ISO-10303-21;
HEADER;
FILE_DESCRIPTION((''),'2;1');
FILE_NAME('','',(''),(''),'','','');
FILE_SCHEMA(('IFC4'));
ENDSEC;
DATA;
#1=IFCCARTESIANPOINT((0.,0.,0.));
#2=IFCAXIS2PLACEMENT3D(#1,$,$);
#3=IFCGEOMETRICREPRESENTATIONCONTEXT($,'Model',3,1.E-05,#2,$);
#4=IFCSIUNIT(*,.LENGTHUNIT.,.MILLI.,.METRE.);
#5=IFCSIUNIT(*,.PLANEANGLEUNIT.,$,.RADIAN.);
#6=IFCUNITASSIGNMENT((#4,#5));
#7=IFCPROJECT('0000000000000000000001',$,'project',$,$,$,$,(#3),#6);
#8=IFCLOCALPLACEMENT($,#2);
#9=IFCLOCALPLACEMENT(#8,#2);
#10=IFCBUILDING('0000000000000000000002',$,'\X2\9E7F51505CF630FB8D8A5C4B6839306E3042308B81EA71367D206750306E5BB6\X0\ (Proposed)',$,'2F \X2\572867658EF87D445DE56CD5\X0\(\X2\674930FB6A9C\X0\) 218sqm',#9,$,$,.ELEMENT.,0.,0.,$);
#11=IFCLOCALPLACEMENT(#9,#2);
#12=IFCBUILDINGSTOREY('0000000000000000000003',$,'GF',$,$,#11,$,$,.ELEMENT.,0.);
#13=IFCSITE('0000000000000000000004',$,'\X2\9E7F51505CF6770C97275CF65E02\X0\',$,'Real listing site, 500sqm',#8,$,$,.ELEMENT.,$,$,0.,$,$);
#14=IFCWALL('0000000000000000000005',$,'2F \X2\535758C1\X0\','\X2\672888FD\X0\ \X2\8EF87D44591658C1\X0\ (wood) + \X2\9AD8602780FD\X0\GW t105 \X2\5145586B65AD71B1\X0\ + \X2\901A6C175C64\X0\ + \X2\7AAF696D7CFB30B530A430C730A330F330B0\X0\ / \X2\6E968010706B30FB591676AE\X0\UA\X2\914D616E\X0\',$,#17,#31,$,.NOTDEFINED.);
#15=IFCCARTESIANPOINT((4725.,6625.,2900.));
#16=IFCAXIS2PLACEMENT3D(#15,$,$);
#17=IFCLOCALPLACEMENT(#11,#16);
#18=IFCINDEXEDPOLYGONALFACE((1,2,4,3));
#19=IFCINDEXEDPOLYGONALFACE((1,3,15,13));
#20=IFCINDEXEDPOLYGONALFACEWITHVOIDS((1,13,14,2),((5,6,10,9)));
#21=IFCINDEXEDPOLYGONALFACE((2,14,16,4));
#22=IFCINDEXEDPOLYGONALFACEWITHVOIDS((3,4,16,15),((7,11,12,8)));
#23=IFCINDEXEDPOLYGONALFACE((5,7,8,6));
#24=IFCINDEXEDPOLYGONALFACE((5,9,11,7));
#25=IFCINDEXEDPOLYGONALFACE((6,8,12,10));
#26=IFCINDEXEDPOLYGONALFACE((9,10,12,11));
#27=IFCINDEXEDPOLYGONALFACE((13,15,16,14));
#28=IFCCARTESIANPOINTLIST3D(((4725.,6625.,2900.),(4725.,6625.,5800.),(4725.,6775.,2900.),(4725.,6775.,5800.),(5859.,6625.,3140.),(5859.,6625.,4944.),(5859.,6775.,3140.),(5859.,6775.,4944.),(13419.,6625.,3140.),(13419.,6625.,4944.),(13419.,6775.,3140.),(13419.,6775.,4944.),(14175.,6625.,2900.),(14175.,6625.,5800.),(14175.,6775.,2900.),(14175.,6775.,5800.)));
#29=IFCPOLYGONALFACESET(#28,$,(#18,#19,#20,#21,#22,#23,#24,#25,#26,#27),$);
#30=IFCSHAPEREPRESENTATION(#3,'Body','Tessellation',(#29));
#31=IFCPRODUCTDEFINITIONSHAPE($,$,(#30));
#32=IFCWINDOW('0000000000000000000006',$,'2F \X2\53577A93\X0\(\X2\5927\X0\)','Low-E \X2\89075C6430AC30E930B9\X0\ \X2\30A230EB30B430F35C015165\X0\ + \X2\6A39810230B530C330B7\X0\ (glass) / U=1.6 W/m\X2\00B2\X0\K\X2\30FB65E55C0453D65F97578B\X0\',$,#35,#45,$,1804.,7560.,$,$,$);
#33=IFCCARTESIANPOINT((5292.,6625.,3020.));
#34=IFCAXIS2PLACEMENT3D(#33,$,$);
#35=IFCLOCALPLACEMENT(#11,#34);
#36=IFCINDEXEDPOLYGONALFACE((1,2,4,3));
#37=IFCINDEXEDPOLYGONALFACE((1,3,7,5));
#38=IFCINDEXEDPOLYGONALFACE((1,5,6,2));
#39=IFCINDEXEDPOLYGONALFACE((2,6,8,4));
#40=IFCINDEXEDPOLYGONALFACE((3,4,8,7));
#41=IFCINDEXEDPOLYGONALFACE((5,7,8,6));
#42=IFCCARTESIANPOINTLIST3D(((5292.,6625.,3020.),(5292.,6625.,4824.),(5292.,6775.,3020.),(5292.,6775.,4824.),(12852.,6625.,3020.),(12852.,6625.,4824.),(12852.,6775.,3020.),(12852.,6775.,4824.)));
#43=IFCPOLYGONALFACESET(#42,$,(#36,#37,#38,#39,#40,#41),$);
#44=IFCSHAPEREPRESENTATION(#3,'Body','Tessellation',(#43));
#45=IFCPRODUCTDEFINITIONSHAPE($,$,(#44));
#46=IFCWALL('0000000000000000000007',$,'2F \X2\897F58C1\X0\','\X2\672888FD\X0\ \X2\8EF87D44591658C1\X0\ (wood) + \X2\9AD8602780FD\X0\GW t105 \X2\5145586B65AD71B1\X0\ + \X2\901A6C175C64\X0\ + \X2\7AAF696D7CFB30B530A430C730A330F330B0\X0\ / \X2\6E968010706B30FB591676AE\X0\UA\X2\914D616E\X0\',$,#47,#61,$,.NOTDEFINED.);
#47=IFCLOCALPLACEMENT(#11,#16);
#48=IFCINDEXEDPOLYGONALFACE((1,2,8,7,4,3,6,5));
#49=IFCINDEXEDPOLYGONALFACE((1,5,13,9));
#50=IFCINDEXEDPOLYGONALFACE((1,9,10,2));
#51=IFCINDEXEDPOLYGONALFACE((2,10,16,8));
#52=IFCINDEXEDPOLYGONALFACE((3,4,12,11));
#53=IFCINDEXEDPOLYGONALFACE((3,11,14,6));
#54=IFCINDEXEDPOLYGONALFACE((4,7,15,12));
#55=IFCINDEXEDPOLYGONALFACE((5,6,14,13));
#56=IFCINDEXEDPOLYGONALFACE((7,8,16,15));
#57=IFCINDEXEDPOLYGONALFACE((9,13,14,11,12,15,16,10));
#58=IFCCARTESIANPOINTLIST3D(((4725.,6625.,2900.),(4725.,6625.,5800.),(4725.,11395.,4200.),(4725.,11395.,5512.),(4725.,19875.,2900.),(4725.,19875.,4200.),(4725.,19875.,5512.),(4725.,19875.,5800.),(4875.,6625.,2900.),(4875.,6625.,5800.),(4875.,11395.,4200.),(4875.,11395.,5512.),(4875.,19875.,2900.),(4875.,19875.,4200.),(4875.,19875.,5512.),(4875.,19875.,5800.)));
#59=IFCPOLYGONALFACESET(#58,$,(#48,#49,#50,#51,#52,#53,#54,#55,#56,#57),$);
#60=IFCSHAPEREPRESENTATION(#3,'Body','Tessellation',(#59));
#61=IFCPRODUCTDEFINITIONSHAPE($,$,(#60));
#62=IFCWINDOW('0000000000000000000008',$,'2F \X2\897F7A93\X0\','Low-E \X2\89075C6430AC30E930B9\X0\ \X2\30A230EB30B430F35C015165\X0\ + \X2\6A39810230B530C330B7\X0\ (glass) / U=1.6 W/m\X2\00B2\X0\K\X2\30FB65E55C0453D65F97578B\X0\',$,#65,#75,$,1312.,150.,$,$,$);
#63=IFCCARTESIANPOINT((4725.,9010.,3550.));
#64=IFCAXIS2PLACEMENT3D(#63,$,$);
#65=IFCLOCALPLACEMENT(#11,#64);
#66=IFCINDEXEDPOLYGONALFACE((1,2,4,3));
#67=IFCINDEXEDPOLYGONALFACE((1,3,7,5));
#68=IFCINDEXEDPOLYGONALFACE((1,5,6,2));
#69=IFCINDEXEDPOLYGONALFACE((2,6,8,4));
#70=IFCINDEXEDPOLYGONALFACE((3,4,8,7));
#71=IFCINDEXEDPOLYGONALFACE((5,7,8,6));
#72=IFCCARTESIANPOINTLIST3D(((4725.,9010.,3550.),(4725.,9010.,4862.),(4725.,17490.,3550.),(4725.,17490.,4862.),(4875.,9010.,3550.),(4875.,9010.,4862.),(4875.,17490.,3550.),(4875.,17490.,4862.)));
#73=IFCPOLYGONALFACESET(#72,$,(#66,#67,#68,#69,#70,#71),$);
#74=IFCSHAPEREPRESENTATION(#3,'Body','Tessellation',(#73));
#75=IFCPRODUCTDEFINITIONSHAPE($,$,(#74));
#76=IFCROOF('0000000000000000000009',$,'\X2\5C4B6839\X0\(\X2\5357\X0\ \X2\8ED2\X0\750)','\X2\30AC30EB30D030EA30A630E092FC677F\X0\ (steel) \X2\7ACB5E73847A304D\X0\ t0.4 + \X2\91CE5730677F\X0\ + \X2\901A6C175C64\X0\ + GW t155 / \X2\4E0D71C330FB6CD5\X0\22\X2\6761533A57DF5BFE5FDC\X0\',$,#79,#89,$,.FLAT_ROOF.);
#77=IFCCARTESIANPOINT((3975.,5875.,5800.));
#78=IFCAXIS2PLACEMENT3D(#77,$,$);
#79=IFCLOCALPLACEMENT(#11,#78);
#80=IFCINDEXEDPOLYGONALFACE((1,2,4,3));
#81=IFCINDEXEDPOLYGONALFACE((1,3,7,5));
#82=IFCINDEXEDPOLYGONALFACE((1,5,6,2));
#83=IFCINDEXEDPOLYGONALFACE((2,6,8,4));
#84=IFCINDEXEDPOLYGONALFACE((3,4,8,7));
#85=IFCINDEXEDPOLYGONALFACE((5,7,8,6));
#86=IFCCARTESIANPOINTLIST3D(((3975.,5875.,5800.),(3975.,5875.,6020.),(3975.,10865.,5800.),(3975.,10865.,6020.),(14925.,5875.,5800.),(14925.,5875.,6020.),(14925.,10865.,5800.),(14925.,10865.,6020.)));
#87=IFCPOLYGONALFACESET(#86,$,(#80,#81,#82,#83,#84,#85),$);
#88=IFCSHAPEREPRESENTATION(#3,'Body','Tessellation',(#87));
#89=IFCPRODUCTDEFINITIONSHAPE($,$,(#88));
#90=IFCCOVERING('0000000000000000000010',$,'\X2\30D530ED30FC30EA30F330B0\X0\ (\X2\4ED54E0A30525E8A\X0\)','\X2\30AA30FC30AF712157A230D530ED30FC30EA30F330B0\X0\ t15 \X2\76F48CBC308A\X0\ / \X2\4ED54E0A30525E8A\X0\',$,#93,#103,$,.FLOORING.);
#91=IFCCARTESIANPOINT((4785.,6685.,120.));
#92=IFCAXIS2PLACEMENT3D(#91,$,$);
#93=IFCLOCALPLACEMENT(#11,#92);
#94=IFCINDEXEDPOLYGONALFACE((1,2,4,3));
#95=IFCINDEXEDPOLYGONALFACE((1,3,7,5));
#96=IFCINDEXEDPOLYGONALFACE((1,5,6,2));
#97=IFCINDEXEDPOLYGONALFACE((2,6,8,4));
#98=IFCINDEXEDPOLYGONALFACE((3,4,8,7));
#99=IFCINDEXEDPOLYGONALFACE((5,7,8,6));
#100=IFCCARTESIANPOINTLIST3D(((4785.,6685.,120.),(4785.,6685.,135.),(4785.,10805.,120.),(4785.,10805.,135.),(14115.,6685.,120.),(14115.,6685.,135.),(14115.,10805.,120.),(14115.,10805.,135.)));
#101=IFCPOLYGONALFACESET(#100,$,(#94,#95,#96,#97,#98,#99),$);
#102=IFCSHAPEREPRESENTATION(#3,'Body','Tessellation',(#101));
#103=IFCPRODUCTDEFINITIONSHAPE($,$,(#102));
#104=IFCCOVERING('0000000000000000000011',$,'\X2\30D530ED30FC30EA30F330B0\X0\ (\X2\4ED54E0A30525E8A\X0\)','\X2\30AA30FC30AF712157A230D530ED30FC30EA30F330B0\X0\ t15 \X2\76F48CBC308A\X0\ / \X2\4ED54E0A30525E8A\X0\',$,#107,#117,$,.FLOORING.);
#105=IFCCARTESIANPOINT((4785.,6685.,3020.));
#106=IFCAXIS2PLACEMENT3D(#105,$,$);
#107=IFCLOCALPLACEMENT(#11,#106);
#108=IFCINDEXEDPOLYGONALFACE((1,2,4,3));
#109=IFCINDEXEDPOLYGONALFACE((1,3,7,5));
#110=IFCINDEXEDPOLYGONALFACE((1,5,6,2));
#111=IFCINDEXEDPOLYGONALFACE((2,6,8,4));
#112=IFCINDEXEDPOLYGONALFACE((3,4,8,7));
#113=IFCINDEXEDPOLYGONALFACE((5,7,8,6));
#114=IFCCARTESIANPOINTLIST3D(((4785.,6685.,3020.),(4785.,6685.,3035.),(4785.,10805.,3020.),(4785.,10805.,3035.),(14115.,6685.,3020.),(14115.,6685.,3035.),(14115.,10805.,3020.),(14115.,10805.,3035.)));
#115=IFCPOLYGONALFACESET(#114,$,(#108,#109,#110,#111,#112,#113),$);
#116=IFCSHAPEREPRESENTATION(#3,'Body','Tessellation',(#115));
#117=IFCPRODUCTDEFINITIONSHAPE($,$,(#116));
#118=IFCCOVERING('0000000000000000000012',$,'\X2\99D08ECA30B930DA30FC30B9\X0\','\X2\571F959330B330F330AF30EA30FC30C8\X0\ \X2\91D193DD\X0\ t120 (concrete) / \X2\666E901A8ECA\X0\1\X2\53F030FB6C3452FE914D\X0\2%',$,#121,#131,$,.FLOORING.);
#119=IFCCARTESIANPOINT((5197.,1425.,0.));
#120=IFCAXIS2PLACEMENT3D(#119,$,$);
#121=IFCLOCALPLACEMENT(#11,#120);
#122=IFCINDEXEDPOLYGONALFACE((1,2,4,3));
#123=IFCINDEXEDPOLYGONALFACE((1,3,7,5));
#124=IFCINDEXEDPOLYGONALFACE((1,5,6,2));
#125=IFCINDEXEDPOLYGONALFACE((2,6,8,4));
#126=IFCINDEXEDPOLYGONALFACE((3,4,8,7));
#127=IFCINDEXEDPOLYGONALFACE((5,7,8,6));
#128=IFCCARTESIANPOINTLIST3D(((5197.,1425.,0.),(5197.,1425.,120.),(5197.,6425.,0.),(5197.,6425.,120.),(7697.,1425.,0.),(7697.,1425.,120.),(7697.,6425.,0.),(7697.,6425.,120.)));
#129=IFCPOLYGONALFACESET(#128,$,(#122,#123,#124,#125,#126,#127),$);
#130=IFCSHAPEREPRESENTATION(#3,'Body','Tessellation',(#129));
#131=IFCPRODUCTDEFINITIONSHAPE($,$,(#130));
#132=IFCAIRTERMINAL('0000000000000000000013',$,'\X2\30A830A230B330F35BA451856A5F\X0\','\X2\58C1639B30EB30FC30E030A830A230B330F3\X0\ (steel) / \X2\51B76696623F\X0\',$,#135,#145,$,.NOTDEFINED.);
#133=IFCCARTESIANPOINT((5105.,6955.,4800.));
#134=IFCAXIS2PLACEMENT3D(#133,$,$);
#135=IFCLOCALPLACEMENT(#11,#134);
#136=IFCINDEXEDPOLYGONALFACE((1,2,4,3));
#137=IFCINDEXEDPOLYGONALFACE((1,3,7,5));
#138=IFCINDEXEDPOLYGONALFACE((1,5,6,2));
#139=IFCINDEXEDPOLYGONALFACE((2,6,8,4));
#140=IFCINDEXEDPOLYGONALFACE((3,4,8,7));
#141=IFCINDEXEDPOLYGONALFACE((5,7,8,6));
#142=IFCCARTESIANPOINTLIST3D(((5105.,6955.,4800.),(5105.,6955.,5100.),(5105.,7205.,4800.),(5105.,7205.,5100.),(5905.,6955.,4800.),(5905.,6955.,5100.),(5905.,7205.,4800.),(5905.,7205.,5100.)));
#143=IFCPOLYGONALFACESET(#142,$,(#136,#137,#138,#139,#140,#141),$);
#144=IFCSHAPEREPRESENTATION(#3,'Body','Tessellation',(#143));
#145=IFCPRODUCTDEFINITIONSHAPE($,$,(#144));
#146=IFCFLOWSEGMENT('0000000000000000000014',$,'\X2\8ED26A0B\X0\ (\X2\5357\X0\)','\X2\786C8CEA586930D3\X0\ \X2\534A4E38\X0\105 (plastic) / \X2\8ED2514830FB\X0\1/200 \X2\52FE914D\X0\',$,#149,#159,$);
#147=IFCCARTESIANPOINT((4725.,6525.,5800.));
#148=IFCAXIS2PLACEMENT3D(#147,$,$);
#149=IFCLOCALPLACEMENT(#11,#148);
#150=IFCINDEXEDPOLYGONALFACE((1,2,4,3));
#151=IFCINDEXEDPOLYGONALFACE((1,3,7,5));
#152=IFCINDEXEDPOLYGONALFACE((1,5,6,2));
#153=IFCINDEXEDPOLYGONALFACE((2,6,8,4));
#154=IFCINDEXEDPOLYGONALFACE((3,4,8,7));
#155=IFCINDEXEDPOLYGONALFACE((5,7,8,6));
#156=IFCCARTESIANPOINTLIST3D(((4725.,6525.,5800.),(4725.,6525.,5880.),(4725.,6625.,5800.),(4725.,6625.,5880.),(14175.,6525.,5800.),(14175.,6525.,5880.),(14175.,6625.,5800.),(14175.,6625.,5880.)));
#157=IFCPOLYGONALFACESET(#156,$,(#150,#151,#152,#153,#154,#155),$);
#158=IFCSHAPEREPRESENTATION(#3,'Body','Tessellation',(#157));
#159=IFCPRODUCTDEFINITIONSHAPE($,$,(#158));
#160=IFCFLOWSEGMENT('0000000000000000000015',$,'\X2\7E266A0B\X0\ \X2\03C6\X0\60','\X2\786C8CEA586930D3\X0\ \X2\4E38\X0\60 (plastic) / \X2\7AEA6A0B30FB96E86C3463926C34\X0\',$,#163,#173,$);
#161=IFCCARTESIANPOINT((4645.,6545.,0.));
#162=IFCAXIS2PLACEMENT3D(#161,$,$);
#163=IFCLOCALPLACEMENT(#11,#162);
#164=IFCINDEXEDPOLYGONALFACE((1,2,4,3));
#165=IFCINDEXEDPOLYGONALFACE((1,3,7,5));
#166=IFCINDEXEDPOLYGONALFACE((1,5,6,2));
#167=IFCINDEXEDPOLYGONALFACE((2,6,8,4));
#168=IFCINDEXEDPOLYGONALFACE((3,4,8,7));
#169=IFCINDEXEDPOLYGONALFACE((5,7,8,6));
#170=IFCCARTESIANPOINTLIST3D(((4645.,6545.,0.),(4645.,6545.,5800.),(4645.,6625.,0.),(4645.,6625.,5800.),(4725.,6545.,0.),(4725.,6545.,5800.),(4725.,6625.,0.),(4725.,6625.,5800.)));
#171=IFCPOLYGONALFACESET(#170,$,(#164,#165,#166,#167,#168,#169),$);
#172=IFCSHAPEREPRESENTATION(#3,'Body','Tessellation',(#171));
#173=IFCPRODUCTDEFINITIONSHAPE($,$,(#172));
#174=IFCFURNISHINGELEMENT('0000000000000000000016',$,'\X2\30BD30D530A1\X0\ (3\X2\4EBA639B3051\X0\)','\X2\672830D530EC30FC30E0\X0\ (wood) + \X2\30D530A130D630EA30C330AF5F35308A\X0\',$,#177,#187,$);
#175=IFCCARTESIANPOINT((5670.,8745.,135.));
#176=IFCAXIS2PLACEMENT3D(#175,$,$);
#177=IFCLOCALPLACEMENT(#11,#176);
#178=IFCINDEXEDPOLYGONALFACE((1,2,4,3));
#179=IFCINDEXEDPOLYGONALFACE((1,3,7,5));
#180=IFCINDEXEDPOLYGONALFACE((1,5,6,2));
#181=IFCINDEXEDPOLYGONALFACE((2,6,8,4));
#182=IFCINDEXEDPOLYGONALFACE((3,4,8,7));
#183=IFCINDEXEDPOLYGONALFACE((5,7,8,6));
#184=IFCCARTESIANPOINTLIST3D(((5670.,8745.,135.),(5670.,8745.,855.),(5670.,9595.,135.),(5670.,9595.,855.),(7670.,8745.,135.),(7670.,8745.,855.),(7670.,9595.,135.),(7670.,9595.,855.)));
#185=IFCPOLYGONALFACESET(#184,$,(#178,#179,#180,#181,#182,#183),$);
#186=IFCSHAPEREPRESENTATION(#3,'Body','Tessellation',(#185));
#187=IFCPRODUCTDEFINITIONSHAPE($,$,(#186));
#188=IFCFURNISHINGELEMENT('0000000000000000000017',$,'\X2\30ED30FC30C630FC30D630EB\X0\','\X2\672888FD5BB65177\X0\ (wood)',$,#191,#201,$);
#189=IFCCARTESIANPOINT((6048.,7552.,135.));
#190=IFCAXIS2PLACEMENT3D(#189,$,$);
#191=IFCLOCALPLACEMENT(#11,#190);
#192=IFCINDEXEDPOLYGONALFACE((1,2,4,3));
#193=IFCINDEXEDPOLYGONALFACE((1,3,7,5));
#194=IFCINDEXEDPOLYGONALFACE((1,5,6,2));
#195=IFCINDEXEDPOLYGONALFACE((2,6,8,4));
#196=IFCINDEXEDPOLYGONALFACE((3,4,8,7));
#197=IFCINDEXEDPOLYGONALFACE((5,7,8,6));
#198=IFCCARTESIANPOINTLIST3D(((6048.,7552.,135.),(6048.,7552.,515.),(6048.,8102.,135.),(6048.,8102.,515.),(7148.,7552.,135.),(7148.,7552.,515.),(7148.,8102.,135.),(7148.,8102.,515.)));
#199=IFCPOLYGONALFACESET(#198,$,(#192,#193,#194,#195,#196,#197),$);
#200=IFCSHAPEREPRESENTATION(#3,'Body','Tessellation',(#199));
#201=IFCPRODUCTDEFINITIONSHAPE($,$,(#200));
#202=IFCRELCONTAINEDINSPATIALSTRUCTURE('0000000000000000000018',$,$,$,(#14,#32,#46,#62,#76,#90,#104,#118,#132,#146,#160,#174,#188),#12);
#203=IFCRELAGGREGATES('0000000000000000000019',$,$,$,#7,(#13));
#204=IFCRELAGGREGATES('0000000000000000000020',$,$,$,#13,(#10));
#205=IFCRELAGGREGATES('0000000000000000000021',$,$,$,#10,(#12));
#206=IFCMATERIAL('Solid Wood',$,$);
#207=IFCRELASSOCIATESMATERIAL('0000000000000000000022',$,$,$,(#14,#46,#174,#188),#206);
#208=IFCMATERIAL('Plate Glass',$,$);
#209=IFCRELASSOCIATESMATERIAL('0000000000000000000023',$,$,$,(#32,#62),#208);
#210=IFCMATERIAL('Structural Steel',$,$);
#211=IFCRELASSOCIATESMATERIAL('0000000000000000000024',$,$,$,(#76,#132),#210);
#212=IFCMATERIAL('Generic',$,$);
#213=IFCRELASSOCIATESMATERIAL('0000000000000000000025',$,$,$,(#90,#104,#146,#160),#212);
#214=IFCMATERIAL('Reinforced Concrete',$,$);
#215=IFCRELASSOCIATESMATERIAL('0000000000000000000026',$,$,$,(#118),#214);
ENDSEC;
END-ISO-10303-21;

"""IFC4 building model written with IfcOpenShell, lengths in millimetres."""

from ifc_helpers import new_model, si_unit, frame, frame_2d, origin, place, context, project, spatial, rectangle, extrude, material, element, fill, save


model = new_model("IFC4")

# Units and contexts
model_context = context("Model", 3, precision=1e-05, world=origin())
ifc_project = project(units=[si_unit("LENGTHUNIT", "METRE", prefix="MILLI"), si_unit("PLANEANGLEUNIT", "RADIAN")], contexts=[model_context])

# Site, building, storey
site_placement = place(None, origin())
site = spatial("IfcSite", under=ifc_project, at=site_placement, Name="鹿児島県霧島市", ObjectType="Real listing site, 500sqm", CompositionType="ELEMENT", RefElevation=0.0)
building_placement = place(site_placement, origin())
building = spatial("IfcBuilding", under=site, at=building_placement, Name="鹿児島・越屋根のある自然素材の家 (Proposed)", ObjectType="2F 在来軸組工法(杉・檜) 218sqm", CompositionType="ELEMENT", ElevationOfRefHeight=0.0, ElevationOfTerrain=0.0)
storey_placement = place(building_placement, origin())
storey = spatial("IfcBuildingStorey", under=building, at=storey_placement, Name="GF", CompositionType="ELEMENT", Elevation=0.0)

# Shared definitions
ifc_material_1 = material(Name="Solid Wood")

# Shared definitions
ifc_material_2 = material(Name="Reinforced Concrete")

# Shared definitions
ifc_material_3 = material(Name="Plate Glass")

# Walls, openings, windows
wall_1_placement = place(storey_placement, frame((4725.0, 6625.0, 2900.0)))
wall_1 = element("IfcWall", 1, at=wall_1_placement, inside=storey, material=ifc_material_1, Name="2F 南壁", Description="木製 軸組外壁 (wood) + 高性能GW t105 充填断熱 + 通気層 + 窯業系サイディング / 準耐火・外皮UA配慮", PredefinedType="NOTDEFINED", context=model_context, shape_type="SweptSolid", body=[
    extrude(rectangle(XDim=9450.0, YDim=150.0, at=frame_2d((4725.0, 75.0))), frame((4725.0, 6625.0, 2900.0)), (0.0, 0.0, 1.0), 2900.0),
])
opening_1_placement = place(storey_placement, frame((5292.0, 6625.0, 3020.0)))
opening_1 = element("IfcOpeningElement", 2, at=opening_1_placement, cuts=wall_1, PredefinedType="NOTDEFINED", context=model_context, shape_type="SweptSolid", body=[
    extrude(rectangle(XDim=7560.0, YDim=150.0, at=frame_2d((3780.0, 75.0))), frame((5292.0, 6625.0, 3020.0)), (0.0, 0.0, 1.0), 1804.0),
])
window_1_placement = place(storey_placement, frame((5292.0, 6625.0, 3020.0)))
window_1 = element("IfcWindow", 3, at=window_1_placement, inside=storey, material=ifc_material_3, Name="2F 南窓(大)", Description="Low-E 複層ガラス アルゴン封入 + 樹脂サッシ (glass) / U=1.6 W/m²K・日射取得型", OverallHeight=1804.0, OverallWidth=7560.0, context=model_context, shape_type="SweptSolid", body=[
    extrude(rectangle(XDim=7560.0, YDim=150.0, at=frame_2d((3780.0, 75.0))), frame((5292.0, 6625.0, 3020.0)), (0.0, 0.0, 1.0), 1804.0),
])
fill(opening_1, window_1)
wall_2_placement = place(storey_placement, frame((4725.0, 6625.0, 2900.0)))
wall_2 = element("IfcWall", 4, at=wall_2_placement, inside=storey, material=ifc_material_1, Name="2F 西壁", Description="木製 軸組外壁 (wood) + 高性能GW t105 充填断熱 + 通気層 + 窯業系サイディング / 準耐火・外皮UA配慮", PredefinedType="NOTDEFINED", context=model_context, shape_type="SweptSolid", body=[
    extrude(rectangle(XDim=150.0, YDim=13250.0, at=frame_2d((75.0, 6625.0))), frame((4725.0, 6625.0, 2900.0)), (0.0, 0.0, 1.0), 2900.0),
])
opening_2_placement = place(storey_placement, frame((4725.0, 9010.0, 3550.0)))
opening_2 = element("IfcOpeningElement", 5, at=opening_2_placement, cuts=wall_2, PredefinedType="NOTDEFINED", context=model_context, shape_type="SweptSolid", body=[
    extrude(rectangle(XDim=150.0, YDim=8480.0, at=frame_2d((75.0, 4240.0))), frame((4725.0, 9010.0, 3550.0)), (0.0, 0.0, 1.0), 1312.0),
])
window_2_placement = place(storey_placement, frame((4725.0, 9010.0, 3550.0)))
window_2 = element("IfcWindow", 6, at=window_2_placement, inside=storey, material=ifc_material_3, Name="2F 西窓", Description="Low-E 複層ガラス アルゴン封入 + 樹脂サッシ (glass) / U=1.6 W/m²K・日射取得型", OverallHeight=1312.0, OverallWidth=150.0, context=model_context, shape_type="SweptSolid", body=[
    extrude(rectangle(XDim=150.0, YDim=8480.0, at=frame_2d((75.0, 4240.0))), frame((4725.0, 9010.0, 3550.0)), (0.0, 0.0, 1.0), 1312.0),
])
fill(opening_2, window_2)

# Roof
ifc_material_4 = material(Name="Structural Steel")
for number, where, name in (
    (7, (3975.0, 5875.0, 5800.0), "屋根(南 軒750)"),
):
    element("IfcRoof", number, at=place(storey_placement, frame(where)), inside=storey, material=ifc_material_4, Name=name, Description="ガルバリウム鋼板 (steel) 立平葺き t0.4 + 野地板 + 通気層 + GW t155 / 不燃・法22条区域対応", PredefinedType="FLAT_ROOF", context=model_context, shape_type="SweptSolid", body=[
        extrude(rectangle(XDim=10950.0, YDim=4990.0, at=frame_2d((5475.0, 2495.0))), frame((3975.0, 5875.0, 5800.0)), (0.0, 0.0, 1.0), 220.0),
    ])

# Coverings
ifc_material_5 = material(Name="Generic")
covering_1_placement = place(storey_placement, frame((4785.0, 6685.0, 120.0)))
element("IfcCovering", 8, at=covering_1_placement, inside=storey, material=ifc_material_5, Name="フローリング (仕上げ床)", Description="オーク無垢フローリング t15 直貼り / 仕上げ床", PredefinedType="FLOORING", context=model_context, shape_type="SweptSolid", body=[
    extrude(rectangle(XDim=9330.0, YDim=4120.0, at=frame_2d((4665.0, 2060.0))), frame((4785.0, 6685.0, 120.0)), (0.0, 0.0, 1.0), 15.0),
])
covering_2_placement = place(storey_placement, frame((4785.0, 6685.0, 3020.0)))
element("IfcCovering", 9, at=covering_2_placement, inside=storey, material=ifc_material_5, Name="フローリング (仕上げ床)", Description="オーク無垢フローリング t15 直貼り / 仕上げ床", PredefinedType="FLOORING", context=model_context, shape_type="SweptSolid", body=[
    extrude(rectangle(XDim=9330.0, YDim=4120.0, at=frame_2d((4665.0, 2060.0))), frame((4785.0, 6685.0, 3020.0)), (0.0, 0.0, 1.0), 15.0),
])
covering_3_placement = place(storey_placement, frame((5197.0, 1425.0, 0.0)))
element("IfcCovering", 10, at=covering_3_placement, inside=storey, material=ifc_material_2, Name="駐車スペース", Description="土間コンクリート 金鏝 t120 (concrete) / 普通車1台・水勾配2%", PredefinedType="FLOORING", context=model_context, shape_type="SweptSolid", body=[
    extrude(rectangle(XDim=2500.0, YDim=5000.0, at=frame_2d((1250.0, 2500.0))), frame((5197.0, 1425.0, 0.0)), (0.0, 0.0, 1.0), 120.0),
])

# Air terminal
air_terminal_placement = place(storey_placement, frame((5105.0, 6955.0, 4800.0)))
element("IfcAirTerminal", 11, at=air_terminal_placement, inside=storey, material=ifc_material_4, Name="エアコン室内機", Description="壁掛ルームエアコン (steel) / 冷暖房", PredefinedType="NOTDEFINED", context=model_context, shape_type="SweptSolid", body=[
    extrude(rectangle(XDim=800.0, YDim=250.0, at=frame_2d((400.0, 125.0))), frame((5105.0, 6955.0, 4800.0)), (0.0, 0.0, 1.0), 300.0),
])

# Flow segments
flow_segment_1_placement = place(storey_placement, frame((4725.0, 6525.0, 5800.0)))
element("IfcFlowSegment", 12, at=flow_segment_1_placement, inside=storey, material=ifc_material_5, Name="軒樋 (南)", Description="硬質塩ビ 半丸105 (plastic) / 軒先・1/200 勾配", context=model_context, shape_type="SweptSolid", body=[
    extrude(rectangle(XDim=9450.0, YDim=100.0, at=frame_2d((4725.0, 50.0))), frame((4725.0, 6525.0, 5800.0)), (0.0, 0.0, 1.0), 80.0),
])
flow_segment_2_placement = place(storey_placement, frame((4645.0, 6545.0, 0.0)))
element("IfcFlowSegment", 13, at=flow_segment_2_placement, inside=storey, material=ifc_material_5, Name="縦樋 φ60", Description="硬質塩ビ 丸60 (plastic) / 竪樋・雨水排水", context=model_context, shape_type="SweptSolid", body=[
    extrude(rectangle(XDim=80.0, YDim=80.0, at=frame_2d((40.0, 40.0))), frame((4645.0, 6545.0, 0.0)), (0.0, 0.0, 1.0), 5800.0),
])

# Furnishing elements
furnishing_1_placement = place(storey_placement, frame((5670.0, 8745.0, 135.0)))
element("IfcFurnishingElement", 14, at=furnishing_1_placement, inside=storey, material=ifc_material_1, Name="ソファ (3人掛け)", Description="木フレーム (wood) + ファブリック張り", context=model_context, shape_type="SweptSolid", body=[
    extrude(rectangle(XDim=2000.0, YDim=850.0, at=frame_2d((1000.0, 425.0))), frame((5670.0, 8745.0, 135.0)), (0.0, 0.0, 1.0), 720.0),
])
furnishing_2_placement = place(storey_placement, frame((6048.0, 7552.0, 135.0)))
element("IfcFurnishingElement", 15, at=furnishing_2_placement, inside=storey, material=ifc_material_1, Name="ローテーブル", Description="木製家具 (wood)", context=model_context, shape_type="SweptSolid", body=[
    extrude(rectangle(XDim=1100.0, YDim=550.0, at=frame_2d((550.0, 275.0))), frame((6048.0, 7552.0, 135.0)), (0.0, 0.0, 1.0), 380.0),
])

save(model, "model.ifc")
